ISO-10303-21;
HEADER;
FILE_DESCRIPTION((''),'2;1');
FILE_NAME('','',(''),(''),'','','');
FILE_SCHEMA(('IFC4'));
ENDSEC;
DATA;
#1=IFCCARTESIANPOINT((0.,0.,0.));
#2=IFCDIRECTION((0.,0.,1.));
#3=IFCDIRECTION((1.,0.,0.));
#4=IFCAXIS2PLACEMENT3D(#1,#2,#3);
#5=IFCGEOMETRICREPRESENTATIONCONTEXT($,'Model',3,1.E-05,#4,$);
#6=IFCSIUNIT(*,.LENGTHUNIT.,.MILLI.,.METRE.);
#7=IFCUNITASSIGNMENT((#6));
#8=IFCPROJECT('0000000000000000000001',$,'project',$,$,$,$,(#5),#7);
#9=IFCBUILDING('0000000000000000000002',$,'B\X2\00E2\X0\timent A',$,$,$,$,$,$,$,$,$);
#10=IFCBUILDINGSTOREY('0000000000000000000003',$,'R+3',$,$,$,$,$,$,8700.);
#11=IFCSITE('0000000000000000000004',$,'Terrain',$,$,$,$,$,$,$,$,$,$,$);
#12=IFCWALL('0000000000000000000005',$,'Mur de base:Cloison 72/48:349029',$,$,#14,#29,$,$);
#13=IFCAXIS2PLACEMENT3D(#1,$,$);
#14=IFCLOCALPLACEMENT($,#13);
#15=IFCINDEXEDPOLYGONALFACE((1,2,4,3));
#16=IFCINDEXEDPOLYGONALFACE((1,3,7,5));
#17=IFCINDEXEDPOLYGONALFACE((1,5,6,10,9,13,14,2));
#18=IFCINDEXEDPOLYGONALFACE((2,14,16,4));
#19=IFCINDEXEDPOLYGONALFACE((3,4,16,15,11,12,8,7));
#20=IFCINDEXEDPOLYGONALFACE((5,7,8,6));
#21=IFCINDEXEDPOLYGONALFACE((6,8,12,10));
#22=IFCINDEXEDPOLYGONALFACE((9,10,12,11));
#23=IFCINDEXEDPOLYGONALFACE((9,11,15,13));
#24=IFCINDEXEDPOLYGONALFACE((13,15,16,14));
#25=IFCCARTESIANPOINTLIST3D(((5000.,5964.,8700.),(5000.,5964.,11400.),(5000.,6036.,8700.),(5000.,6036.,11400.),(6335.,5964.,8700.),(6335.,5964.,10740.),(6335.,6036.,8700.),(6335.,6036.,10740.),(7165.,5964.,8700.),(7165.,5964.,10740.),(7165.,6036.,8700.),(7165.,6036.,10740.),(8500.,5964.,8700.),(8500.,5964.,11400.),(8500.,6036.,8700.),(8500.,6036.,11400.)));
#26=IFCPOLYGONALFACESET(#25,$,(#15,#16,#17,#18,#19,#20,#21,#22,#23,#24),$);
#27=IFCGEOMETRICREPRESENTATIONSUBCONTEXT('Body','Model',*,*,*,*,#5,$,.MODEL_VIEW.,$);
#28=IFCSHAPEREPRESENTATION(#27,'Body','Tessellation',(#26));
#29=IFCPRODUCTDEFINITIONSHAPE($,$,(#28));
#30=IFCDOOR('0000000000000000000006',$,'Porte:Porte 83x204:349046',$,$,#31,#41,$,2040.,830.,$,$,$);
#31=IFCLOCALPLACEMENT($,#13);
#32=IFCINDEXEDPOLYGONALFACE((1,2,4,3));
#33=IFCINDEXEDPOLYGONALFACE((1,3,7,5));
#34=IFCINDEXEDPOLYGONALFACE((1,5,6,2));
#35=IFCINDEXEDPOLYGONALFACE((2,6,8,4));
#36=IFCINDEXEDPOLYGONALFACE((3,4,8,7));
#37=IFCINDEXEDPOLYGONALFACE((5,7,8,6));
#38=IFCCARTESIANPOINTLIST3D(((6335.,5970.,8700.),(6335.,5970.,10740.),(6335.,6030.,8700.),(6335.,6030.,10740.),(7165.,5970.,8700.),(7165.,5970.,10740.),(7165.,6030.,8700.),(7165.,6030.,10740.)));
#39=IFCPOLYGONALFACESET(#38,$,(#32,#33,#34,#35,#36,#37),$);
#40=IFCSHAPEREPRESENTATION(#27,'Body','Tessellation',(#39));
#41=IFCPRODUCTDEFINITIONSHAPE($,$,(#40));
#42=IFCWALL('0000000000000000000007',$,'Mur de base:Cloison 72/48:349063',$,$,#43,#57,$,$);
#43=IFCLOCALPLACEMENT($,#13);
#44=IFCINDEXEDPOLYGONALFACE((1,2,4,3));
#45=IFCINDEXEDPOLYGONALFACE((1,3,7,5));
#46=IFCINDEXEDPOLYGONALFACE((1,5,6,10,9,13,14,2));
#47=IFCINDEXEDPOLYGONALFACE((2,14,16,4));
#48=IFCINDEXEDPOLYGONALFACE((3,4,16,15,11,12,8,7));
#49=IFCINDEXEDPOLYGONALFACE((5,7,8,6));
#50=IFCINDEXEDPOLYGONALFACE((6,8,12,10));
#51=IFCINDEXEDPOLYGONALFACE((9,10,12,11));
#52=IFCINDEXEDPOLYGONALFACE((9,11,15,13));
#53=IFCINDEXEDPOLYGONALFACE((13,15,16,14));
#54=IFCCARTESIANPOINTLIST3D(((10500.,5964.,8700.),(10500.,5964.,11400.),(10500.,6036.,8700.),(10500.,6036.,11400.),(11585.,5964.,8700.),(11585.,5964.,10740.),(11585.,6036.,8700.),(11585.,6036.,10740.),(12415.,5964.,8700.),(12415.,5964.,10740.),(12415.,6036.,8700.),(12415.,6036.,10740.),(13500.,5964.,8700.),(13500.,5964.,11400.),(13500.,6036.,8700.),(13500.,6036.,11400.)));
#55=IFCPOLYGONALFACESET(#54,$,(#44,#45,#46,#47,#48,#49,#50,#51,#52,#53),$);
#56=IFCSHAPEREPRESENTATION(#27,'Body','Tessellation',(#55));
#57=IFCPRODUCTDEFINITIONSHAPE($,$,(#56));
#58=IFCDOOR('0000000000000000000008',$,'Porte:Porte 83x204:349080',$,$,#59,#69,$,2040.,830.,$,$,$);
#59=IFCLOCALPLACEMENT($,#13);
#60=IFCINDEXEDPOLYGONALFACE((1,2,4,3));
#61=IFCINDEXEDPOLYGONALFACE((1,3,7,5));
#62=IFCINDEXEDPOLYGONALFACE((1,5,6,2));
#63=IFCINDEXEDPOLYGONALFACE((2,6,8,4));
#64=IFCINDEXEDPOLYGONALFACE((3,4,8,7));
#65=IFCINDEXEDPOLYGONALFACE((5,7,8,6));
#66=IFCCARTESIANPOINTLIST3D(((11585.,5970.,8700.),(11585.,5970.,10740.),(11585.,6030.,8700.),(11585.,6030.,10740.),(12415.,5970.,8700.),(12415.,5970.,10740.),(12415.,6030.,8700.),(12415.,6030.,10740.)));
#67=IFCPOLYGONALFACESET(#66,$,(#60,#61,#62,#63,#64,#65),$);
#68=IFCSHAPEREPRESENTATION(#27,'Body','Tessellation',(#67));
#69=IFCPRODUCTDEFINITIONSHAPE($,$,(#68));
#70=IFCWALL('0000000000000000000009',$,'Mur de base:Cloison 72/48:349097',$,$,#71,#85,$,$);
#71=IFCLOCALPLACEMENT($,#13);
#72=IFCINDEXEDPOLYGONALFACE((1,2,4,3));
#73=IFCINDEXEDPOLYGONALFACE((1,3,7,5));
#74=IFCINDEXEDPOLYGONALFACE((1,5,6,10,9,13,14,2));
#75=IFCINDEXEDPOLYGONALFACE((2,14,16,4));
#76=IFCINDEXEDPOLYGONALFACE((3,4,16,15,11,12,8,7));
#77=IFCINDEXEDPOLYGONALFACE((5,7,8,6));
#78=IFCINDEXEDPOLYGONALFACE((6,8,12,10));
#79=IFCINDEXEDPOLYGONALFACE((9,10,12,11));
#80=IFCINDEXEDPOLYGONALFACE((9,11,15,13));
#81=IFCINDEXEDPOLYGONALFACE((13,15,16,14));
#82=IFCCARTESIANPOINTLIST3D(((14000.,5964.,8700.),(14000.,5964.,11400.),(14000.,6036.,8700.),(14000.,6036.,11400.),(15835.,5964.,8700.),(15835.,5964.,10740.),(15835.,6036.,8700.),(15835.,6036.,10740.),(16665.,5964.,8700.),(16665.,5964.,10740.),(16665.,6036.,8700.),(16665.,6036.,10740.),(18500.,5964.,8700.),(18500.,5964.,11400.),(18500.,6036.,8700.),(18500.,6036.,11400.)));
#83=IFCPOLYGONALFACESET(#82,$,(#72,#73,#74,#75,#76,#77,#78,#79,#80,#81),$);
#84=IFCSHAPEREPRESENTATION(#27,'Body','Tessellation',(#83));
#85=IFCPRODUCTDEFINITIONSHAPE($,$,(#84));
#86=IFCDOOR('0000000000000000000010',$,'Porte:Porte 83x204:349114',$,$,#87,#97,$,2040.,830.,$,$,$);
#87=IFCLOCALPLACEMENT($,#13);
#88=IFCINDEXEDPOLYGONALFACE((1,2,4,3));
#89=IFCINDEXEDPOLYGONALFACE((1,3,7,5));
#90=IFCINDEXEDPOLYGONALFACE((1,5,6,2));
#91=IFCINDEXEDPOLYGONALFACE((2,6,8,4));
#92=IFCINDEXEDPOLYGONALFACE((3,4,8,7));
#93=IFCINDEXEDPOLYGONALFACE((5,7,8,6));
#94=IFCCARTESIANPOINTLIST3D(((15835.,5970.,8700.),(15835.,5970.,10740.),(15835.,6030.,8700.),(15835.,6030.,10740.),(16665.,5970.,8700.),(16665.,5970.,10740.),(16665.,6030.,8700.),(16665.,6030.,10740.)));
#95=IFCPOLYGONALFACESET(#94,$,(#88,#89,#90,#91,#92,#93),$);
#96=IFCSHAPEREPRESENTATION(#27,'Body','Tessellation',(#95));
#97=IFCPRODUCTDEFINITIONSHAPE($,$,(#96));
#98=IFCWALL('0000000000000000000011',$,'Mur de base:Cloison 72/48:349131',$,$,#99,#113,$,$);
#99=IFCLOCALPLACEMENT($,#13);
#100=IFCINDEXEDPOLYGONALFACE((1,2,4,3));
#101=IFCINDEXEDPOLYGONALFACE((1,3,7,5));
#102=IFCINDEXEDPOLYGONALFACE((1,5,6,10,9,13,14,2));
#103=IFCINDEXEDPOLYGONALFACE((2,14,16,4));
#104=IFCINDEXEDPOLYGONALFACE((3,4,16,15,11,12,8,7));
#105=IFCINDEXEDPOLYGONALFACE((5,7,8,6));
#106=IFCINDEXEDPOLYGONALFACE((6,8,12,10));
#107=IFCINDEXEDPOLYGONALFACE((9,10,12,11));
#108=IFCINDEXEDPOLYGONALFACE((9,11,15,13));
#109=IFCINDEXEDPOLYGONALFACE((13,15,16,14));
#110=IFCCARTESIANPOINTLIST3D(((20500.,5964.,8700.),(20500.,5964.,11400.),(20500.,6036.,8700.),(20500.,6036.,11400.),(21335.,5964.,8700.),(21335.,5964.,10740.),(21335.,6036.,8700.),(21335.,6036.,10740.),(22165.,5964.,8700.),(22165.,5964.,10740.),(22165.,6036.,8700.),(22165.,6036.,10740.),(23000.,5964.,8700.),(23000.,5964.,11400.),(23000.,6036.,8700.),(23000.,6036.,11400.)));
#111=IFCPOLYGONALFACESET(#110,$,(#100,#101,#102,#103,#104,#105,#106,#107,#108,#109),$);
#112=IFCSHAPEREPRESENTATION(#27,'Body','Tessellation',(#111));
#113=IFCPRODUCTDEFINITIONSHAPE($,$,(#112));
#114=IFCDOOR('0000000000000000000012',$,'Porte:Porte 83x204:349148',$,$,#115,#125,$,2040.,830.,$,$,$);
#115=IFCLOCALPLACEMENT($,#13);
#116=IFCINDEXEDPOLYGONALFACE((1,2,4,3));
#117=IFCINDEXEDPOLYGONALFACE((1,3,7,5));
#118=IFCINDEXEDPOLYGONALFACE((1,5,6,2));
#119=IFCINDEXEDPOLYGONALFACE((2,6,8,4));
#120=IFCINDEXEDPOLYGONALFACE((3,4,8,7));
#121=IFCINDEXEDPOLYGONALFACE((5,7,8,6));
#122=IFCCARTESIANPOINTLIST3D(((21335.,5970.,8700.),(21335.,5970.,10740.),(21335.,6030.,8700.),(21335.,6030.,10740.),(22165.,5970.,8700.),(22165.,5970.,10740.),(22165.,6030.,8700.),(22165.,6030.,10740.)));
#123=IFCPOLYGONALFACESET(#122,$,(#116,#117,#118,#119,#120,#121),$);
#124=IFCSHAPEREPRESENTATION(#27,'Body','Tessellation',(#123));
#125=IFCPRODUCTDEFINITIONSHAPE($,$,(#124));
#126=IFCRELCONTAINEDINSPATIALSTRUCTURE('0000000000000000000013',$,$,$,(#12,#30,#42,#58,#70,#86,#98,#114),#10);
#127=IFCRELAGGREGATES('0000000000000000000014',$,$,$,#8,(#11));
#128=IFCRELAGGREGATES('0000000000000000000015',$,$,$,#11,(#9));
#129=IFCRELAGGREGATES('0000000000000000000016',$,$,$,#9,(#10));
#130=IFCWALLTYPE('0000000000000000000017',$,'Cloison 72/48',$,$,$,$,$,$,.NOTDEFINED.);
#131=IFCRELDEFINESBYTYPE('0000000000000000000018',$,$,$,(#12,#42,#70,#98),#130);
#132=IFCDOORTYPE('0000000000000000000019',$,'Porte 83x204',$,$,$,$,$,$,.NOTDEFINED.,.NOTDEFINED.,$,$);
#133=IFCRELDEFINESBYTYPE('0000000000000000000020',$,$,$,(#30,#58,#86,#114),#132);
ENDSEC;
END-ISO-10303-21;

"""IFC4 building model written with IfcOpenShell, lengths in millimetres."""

from ifc_helpers import new_model, si_unit, frame, frame_2d, origin_with_axes, place, context, subcontext, project, spatial, rectangle, extrude, type_object, element, fill, save


model = new_model("IFC4")

# Units and contexts
model_context = context("Model", 3, precision=1e-05, world=origin_with_axes())
body_context = subcontext(model_context, "Body", "Model", "MODEL_VIEW")
ifc_project = project(units=[si_unit("LENGTHUNIT", "METRE", prefix="MILLI")], contexts=[model_context])

# Site, building, storey
site = spatial("IfcSite", under=ifc_project, Name="Terrain")
building = spatial("IfcBuilding", under=site, Name="Bâtiment A")
storey = spatial("IfcBuildingStorey", under=building, Name="R+3", Elevation=8700.0)

# Walls, openings, doors
door_type = type_object("IfcDoorType", Name="Porte 83x204", OperationType="NOTDEFINED", PredefinedType="NOTDEFINED")
wall_type_1 = type_object("IfcWallType", Name="Cloison 72/48", PredefinedType="NOTDEFINED")
wall_1_placement = place(None, origin_with_axes())
wall_1 = element("IfcWall", 1, at=wall_1_placement, inside=storey, type_object=wall_type_1, Name="Mur de base:Cloison 72/48:349029", context=body_context, shape_type="SweptSolid", body=[
    extrude(rectangle(XDim=3500.0, YDim=72.0, at=frame_2d((6750.0, 6000.0))), frame((0.0, 0.0, 8700.0), z_axis=(0.0, 0.0, 1.0), x_axis=(1.0, 0.0, 0.0)), (0.0, 0.0, 1.0), 2700.0),
])
opening_1_placement = place(None, origin_with_axes())
opening_1 = element("IfcOpeningElement", 2, at=opening_1_placement, cuts=wall_1, context=body_context, shape_type="SweptSolid", body=[
    extrude(rectangle(XDim=830.0, YDim=192.0, at=frame_2d((6750.0, 6000.0))), frame((0.0, 0.0, 8700.0), z_axis=(0.0, 0.0, 1.0), x_axis=(1.0, 0.0, 0.0)), (0.0, 0.0, 1.0), 2040.0),
])
door_1_placement = place(None, origin_with_axes())
door_1 = element("IfcDoor", 3, at=door_1_placement, inside=storey, type_object=door_type, Name="Porte:Porte 83x204:349046", OverallHeight=2040.0, OverallWidth=830.0, context=body_context, shape_type="SweptSolid", body=[
    extrude(rectangle(XDim=830.0, YDim=60.0, at=frame_2d((6750.0, 6000.0))), frame((0.0, 0.0, 8700.0), z_axis=(0.0, 0.0, 1.0), x_axis=(1.0, 0.0, 0.0)), (0.0, 0.0, 1.0), 2040.0),
])
fill(opening_1, door_1)
wall_2_placement = place(None, origin_with_axes())
wall_2 = element("IfcWall", 4, at=wall_2_placement, inside=storey, type_object=wall_type_1, Name="Mur de base:Cloison 72/48:349063", context=body_context, shape_type="SweptSolid", body=[
    extrude(rectangle(XDim=3000.0, YDim=72.0, at=frame_2d((12000.0, 6000.0))), frame((0.0, 0.0, 8700.0), z_axis=(0.0, 0.0, 1.0), x_axis=(1.0, 0.0, 0.0)), (0.0, 0.0, 1.0), 2700.0),
])
opening_2_placement = place(None, origin_with_axes())
opening_2 = element("IfcOpeningElement", 5, at=opening_2_placement, cuts=wall_2, context=body_context, shape_type="SweptSolid", body=[
    extrude(rectangle(XDim=830.0, YDim=192.0, at=frame_2d((12000.0, 6000.0))), frame((0.0, 0.0, 8700.0), z_axis=(0.0, 0.0, 1.0), x_axis=(1.0, 0.0, 0.0)), (0.0, 0.0, 1.0), 2040.0),
])
door_2_placement = place(None, origin_with_axes())
door_2 = element("IfcDoor", 6, at=door_2_placement, inside=storey, type_object=door_type, Name="Porte:Porte 83x204:349080", OverallHeight=2040.0, OverallWidth=830.0, context=body_context, shape_type="SweptSolid", body=[
    extrude(rectangle(XDim=830.0, YDim=60.0, at=frame_2d((12000.0, 6000.0))), frame((0.0, 0.0, 8700.0), z_axis=(0.0, 0.0, 1.0), x_axis=(1.0, 0.0, 0.0)), (0.0, 0.0, 1.0), 2040.0),
])
fill(opening_2, door_2)
wall_3_placement = place(None, origin_with_axes())
wall_3 = element("IfcWall", 7, at=wall_3_placement, inside=storey, type_object=wall_type_1, Name="Mur de base:Cloison 72/48:349097", context=body_context, shape_type="SweptSolid", body=[
    extrude(rectangle(XDim=4500.0, YDim=72.0, at=frame_2d((16250.0, 6000.0))), frame((0.0, 0.0, 8700.0), z_axis=(0.0, 0.0, 1.0), x_axis=(1.0, 0.0, 0.0)), (0.0, 0.0, 1.0), 2700.0),
])
opening_3_placement = place(None, origin_with_axes())
opening_3 = element("IfcOpeningElement", 8, at=opening_3_placement, cuts=wall_3, context=body_context, shape_type="SweptSolid", body=[
    extrude(rectangle(XDim=830.0, YDim=192.0, at=frame_2d((16250.0, 6000.0))), frame((0.0, 0.0, 8700.0), z_axis=(0.0, 0.0, 1.0), x_axis=(1.0, 0.0, 0.0)), (0.0, 0.0, 1.0), 2040.0),
])
door_3_placement = place(None, origin_with_axes())
door_3 = element("IfcDoor", 9, at=door_3_placement, inside=storey, type_object=door_type, Name="Porte:Porte 83x204:349114", OverallHeight=2040.0, OverallWidth=830.0, context=body_context, shape_type="SweptSolid", body=[
    extrude(rectangle(XDim=830.0, YDim=60.0, at=frame_2d((16250.0, 6000.0))), frame((0.0, 0.0, 8700.0), z_axis=(0.0, 0.0, 1.0), x_axis=(1.0, 0.0, 0.0)), (0.0, 0.0, 1.0), 2040.0),
])
fill(opening_3, door_3)
wall_4_placement = place(None, origin_with_axes())
wall_4 = element("IfcWall", 10, at=wall_4_placement, inside=storey, type_object=wall_type_1, Name="Mur de base:Cloison 72/48:349131", context=body_context, shape_type="SweptSolid", body=[
    extrude(rectangle(XDim=2500.0, YDim=72.0, at=frame_2d((21750.0, 6000.0))), frame((0.0, 0.0, 8700.0), z_axis=(0.0, 0.0, 1.0), x_axis=(1.0, 0.0, 0.0)), (0.0, 0.0, 1.0), 2700.0),
])
opening_4_placement = place(None, origin_with_axes())
opening_4 = element("IfcOpeningElement", 11, at=opening_4_placement, cuts=wall_4, context=body_context, shape_type="SweptSolid", body=[
    extrude(rectangle(XDim=830.0, YDim=192.0, at=frame_2d((21750.0, 6000.0))), frame((0.0, 0.0, 8700.0), z_axis=(0.0, 0.0, 1.0), x_axis=(1.0, 0.0, 0.0)), (0.0, 0.0, 1.0), 2040.0),
])
door_4_placement = place(None, origin_with_axes())
door_4 = element("IfcDoor", 12, at=door_4_placement, inside=storey, type_object=door_type, Name="Porte:Porte 83x204:349148", OverallHeight=2040.0, OverallWidth=830.0, context=body_context, shape_type="SweptSolid", body=[
    extrude(rectangle(XDim=830.0, YDim=60.0, at=frame_2d((21750.0, 6000.0))), frame((0.0, 0.0, 8700.0), z_axis=(0.0, 0.0, 1.0), x_axis=(1.0, 0.0, 0.0)), (0.0, 0.0, 1.0), 2040.0),
])
fill(opening_4, door_4)

save(model, "model.ifc")
